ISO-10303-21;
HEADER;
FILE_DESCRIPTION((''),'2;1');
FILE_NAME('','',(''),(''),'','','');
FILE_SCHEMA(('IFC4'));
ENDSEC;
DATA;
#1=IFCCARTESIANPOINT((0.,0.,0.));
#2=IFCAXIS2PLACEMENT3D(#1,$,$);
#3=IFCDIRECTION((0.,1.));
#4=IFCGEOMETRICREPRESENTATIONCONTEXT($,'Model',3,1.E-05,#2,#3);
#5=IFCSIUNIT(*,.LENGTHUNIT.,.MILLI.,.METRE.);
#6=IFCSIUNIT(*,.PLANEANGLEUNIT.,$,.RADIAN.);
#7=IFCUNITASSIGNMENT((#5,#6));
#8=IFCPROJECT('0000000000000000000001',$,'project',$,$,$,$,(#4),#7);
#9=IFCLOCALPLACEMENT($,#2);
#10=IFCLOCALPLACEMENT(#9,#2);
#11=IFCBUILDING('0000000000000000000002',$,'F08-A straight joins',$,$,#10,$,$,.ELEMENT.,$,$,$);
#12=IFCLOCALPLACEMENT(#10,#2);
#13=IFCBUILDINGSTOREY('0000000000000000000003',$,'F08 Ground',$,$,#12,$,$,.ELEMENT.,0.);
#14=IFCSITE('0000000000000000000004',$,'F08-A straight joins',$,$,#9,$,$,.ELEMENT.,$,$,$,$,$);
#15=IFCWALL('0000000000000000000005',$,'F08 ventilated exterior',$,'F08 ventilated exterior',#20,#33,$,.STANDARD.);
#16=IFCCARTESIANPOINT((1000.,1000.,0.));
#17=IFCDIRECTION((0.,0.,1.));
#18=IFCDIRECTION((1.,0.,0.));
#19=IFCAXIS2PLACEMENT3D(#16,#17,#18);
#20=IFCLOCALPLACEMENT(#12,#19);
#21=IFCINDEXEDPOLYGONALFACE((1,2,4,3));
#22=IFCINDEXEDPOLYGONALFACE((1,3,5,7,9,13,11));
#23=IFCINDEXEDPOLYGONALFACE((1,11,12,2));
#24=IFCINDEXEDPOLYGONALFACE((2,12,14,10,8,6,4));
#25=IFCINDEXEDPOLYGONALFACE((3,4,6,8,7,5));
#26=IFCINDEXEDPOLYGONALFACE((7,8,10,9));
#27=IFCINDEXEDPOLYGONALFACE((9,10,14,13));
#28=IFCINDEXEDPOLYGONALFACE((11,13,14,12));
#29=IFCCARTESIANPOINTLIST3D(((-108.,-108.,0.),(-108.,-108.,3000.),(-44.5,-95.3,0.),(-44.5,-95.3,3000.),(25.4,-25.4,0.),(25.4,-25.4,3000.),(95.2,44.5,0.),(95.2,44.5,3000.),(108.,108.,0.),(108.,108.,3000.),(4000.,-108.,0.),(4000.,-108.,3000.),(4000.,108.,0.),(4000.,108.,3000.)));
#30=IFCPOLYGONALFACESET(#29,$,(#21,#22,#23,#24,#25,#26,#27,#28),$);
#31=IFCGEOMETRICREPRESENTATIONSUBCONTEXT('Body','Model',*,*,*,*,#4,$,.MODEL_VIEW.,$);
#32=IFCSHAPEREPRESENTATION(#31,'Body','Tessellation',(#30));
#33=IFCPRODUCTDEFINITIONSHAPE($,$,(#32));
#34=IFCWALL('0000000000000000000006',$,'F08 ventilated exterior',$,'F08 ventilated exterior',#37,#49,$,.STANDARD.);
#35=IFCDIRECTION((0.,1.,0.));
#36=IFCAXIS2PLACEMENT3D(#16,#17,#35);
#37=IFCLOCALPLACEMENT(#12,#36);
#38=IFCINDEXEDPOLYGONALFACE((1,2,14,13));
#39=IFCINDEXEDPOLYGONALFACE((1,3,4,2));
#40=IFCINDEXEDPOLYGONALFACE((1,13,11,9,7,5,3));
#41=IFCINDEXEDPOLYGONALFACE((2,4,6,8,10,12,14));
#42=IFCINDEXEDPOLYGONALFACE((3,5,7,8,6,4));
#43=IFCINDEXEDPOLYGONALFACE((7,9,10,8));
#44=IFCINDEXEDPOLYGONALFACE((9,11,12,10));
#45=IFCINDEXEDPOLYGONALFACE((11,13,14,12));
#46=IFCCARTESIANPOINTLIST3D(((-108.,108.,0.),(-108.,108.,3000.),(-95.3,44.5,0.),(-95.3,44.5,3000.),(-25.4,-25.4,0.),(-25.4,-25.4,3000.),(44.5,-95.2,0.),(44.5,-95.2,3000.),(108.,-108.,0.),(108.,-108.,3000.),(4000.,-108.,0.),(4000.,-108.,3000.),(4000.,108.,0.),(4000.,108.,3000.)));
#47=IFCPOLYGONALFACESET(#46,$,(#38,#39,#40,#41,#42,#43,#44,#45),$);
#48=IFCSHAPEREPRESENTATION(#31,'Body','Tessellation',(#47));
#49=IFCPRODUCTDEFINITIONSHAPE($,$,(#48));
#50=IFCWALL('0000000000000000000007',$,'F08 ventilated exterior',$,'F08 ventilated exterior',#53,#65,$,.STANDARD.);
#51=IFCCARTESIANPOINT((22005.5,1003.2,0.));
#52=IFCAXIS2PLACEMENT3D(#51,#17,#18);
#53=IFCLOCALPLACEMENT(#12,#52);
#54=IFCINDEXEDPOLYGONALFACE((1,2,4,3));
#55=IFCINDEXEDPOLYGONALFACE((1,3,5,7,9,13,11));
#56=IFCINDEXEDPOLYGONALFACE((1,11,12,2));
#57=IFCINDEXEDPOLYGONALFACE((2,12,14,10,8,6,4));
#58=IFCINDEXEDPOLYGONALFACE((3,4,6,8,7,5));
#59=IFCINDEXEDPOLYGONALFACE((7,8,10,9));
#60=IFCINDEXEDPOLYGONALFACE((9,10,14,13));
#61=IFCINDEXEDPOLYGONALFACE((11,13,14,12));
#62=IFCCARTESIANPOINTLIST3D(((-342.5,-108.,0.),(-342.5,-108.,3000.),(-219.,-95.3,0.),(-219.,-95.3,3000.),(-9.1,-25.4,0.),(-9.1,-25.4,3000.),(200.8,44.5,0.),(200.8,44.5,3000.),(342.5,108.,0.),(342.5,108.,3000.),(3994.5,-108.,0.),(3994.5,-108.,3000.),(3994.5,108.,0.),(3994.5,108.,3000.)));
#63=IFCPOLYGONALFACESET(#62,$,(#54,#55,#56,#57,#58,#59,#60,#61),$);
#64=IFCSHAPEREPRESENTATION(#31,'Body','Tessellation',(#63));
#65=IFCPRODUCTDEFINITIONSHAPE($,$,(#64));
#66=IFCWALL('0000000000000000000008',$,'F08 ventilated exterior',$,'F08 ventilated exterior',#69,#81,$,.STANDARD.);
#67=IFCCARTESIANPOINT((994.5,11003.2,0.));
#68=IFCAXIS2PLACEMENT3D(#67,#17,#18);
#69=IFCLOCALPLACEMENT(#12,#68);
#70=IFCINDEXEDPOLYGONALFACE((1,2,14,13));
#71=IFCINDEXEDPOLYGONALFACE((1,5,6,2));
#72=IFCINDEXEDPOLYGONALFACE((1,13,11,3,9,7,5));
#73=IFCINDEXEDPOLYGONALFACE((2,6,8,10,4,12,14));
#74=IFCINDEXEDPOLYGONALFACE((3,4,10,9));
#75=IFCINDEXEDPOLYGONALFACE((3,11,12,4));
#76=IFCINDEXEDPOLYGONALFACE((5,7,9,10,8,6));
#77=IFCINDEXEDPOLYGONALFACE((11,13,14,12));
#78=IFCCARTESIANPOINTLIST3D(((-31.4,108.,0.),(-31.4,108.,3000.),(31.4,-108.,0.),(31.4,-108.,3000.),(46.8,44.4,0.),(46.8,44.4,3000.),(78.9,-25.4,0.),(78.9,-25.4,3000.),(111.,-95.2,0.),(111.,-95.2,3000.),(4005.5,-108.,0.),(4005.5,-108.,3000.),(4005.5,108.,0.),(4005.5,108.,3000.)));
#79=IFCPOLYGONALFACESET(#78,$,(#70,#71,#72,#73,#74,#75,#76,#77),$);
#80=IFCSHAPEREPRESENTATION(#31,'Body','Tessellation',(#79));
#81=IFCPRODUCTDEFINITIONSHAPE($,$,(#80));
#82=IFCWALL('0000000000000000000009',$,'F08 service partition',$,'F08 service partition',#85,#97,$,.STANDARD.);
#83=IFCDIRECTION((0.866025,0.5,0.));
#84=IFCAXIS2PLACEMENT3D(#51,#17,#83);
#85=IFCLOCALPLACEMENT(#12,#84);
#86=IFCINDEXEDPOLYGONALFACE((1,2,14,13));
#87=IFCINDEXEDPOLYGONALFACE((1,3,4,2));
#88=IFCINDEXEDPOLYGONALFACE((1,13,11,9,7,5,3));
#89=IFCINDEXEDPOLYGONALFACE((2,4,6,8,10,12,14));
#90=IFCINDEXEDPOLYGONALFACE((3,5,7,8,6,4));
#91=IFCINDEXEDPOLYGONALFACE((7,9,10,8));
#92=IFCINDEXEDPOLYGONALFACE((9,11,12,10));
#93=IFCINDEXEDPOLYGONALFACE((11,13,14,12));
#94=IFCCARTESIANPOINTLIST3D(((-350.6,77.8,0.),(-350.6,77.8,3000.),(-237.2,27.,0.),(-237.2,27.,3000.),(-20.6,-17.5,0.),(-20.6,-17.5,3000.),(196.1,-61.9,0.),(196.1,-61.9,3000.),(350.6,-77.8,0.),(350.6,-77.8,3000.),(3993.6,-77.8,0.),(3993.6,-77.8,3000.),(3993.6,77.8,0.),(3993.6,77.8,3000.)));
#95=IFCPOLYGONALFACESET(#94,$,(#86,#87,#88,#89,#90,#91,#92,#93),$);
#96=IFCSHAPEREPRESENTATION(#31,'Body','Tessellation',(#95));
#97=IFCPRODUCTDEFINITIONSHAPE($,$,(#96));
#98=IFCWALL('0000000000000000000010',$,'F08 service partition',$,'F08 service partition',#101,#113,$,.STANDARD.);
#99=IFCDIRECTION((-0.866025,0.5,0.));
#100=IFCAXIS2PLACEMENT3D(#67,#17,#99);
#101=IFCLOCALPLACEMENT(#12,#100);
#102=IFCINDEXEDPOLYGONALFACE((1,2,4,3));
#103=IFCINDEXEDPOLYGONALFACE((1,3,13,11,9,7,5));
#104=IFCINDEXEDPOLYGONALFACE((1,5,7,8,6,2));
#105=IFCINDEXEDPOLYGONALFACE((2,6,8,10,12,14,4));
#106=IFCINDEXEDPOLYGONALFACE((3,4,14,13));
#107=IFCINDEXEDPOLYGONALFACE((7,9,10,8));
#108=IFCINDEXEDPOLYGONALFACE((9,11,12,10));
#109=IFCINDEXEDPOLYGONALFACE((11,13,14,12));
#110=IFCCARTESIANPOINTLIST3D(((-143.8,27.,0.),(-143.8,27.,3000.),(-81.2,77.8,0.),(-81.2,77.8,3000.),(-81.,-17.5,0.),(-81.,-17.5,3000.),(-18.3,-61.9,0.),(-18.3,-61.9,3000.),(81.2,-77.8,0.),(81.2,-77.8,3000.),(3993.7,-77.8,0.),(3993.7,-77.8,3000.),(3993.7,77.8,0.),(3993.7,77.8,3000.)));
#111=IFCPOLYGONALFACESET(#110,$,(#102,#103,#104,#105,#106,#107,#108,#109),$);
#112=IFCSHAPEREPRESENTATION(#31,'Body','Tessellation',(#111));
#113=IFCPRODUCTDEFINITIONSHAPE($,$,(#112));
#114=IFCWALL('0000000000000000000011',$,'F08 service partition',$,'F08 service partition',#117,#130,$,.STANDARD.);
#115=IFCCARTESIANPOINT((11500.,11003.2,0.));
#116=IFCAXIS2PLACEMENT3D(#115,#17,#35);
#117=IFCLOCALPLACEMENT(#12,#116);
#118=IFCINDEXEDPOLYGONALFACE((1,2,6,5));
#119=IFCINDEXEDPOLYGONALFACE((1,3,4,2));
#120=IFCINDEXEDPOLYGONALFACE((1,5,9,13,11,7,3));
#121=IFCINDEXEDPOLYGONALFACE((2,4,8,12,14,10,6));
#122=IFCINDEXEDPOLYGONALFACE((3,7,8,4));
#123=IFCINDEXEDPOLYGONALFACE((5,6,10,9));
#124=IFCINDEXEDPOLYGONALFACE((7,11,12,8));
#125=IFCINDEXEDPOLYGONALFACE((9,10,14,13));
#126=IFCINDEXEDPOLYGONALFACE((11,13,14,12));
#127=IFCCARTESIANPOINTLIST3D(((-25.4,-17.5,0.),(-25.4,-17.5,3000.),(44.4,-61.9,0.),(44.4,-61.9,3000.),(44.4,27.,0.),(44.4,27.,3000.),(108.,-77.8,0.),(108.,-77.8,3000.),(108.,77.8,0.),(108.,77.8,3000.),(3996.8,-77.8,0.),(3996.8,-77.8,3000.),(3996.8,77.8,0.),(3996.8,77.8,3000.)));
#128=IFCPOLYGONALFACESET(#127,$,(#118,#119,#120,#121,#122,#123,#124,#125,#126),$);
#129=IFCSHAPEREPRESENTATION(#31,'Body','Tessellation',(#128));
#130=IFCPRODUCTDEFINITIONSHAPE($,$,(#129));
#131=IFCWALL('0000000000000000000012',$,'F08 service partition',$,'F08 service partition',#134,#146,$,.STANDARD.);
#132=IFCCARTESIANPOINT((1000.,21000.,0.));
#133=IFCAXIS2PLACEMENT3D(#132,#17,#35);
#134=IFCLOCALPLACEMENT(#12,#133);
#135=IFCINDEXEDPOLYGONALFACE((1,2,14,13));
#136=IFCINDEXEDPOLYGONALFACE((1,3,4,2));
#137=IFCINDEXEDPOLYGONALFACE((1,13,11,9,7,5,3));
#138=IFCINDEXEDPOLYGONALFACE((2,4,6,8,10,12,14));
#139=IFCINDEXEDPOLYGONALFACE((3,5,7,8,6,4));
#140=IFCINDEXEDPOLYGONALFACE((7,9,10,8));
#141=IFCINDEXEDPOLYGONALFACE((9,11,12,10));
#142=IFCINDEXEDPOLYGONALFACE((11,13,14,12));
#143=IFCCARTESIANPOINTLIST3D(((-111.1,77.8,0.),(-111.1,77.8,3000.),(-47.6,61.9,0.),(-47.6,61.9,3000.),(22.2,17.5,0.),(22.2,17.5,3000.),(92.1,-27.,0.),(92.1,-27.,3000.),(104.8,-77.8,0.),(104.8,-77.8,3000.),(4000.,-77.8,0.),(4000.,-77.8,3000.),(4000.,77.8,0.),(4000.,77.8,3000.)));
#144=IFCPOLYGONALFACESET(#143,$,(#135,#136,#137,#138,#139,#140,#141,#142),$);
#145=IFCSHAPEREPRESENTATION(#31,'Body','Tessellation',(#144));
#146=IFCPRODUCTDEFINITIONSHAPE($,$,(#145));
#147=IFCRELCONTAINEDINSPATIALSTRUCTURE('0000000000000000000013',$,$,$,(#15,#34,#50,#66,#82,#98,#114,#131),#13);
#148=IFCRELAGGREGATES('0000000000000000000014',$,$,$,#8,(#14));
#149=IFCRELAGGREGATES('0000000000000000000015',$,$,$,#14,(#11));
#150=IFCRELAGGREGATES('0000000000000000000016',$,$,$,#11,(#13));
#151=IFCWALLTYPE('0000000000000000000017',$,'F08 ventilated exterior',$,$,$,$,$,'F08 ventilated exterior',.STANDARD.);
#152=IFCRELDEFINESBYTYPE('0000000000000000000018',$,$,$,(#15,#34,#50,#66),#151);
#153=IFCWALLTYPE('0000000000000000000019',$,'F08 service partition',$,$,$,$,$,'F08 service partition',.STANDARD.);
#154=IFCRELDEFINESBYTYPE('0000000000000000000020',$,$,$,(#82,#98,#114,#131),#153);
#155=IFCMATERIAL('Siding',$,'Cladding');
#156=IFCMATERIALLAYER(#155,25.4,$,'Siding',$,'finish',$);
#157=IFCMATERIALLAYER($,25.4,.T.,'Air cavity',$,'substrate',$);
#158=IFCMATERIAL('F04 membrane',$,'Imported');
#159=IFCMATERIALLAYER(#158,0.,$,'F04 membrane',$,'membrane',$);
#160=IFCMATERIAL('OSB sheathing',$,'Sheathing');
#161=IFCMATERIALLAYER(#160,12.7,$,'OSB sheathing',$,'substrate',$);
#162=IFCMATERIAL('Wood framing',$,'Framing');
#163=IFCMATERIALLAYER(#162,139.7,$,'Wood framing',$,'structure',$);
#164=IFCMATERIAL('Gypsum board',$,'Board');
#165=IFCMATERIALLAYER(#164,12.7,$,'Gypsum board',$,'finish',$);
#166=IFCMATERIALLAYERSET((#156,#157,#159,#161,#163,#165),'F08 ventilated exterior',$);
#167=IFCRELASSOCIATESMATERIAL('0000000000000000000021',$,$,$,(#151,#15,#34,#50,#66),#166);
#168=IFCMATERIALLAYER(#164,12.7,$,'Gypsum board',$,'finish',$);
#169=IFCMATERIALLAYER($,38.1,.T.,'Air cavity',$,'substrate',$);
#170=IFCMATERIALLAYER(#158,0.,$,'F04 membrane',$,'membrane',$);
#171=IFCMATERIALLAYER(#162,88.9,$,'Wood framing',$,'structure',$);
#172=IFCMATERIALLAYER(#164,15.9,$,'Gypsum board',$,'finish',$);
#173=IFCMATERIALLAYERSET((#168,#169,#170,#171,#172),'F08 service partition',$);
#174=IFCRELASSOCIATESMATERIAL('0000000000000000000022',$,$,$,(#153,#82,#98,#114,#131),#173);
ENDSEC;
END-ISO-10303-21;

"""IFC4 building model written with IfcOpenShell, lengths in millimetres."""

from ifc_helpers import new_model, si_unit, direction, frame, origin, place, context, subcontext, project, spatial, polyline, outline, extrude, material, layer, layer_set, layer_usage, type_object, element, save


model = new_model("IFC4")

# Units and contexts
model_context = context("Model", 3, precision=1e-05, world=origin(), true_north=direction((0.0, 1.0)))
body_context = subcontext(model_context, "Body", "Model", "MODEL_VIEW")
ifc_project = project(units=[si_unit("LENGTHUNIT", "METRE", prefix="MILLI"), si_unit("PLANEANGLEUNIT", "RADIAN")], contexts=[model_context])

# Site, building, storey
site_placement = place(None, origin())
site = spatial("IfcSite", under=ifc_project, at=site_placement, Name="F08-A straight joins", CompositionType="ELEMENT")
building_placement = place(site_placement, origin())
building = spatial("IfcBuilding", under=site, at=building_placement, Name="F08-A straight joins", CompositionType="ELEMENT")
storey_placement = place(building_placement, origin())
storey = spatial("IfcBuildingStorey", under=building, at=storey_placement, Name="F08 Ground", CompositionType="ELEMENT", Elevation=0.0)

# Walls
ifc_material_1 = material(Name="Siding", Category="Cladding")
ifc_layer_1 = layer(ifc_material_1, 25.4, Name="Siding", Category="finish")
ifc_layer_2 = layer(None, 25.4, ventilated=True, Name="Air cavity", Category="substrate")
ifc_material_2 = material(Name="F04 membrane", Category="Imported")
ifc_layer_3 = layer(ifc_material_2, 0.0, Name="F04 membrane", Category="membrane")
ifc_material_3 = material(Name="OSB sheathing", Category="Sheathing")
ifc_layer_4 = layer(ifc_material_3, 12.7, Name="OSB sheathing", Category="substrate")
ifc_material_4 = material(Name="Wood framing", Category="Framing")
ifc_layer_5 = layer(ifc_material_4, 139.7, Name="Wood framing", Category="structure")
ifc_material_5 = material(Name="Gypsum board", Category="Board")
ifc_layer_6 = layer(ifc_material_5, 12.7, Name="Gypsum board", Category="finish")
ifc_layer_set_1 = layer_set([ifc_layer_1, ifc_layer_2, ifc_layer_3, ifc_layer_4, ifc_layer_5, ifc_layer_6], Name="F08 ventilated exterior")
ifc_layer_usage_1 = layer_usage(ifc_layer_set_1, "AXIS2", "NEGATIVE", 108.0)
wall_type_1 = type_object("IfcWallType", Name="F08 ventilated exterior", ElementType="F08 ventilated exterior", PredefinedType="STANDARD", material=ifc_layer_set_1)
wall_1_placement = place(storey_placement, frame((1000.0, 1000.0, 0.0), z_axis=(0.0, 0.0, 1.0), x_axis=(1.0, 0.0, 0.0)))
element("IfcWall", 1, at=wall_1_placement, inside=storey, type_object=wall_type_1, material=ifc_layer_usage_1, Name="F08 ventilated exterior", ObjectType="F08 ventilated exterior", PredefinedType="STANDARD", context=body_context, shape_type="SweptSolid", body=[
    extrude(outline(polyline([(-108.0, -108.0), (4000.0, -108.0), (4000.0, 108.0), (108.0, 108.0), (95.2, 44.5), (25.4, -25.4), (-44.5, -95.2), (-108.0, -108.0)])), origin(), (0.0, 0.0, 1.0), 3000.0),
])
ifc_layer_usage_2 = layer_usage(ifc_layer_set_1, "AXIS2", "NEGATIVE", 108.0)
wall_2_placement = place(storey_placement, frame((1000.0, 1000.0, 0.0), z_axis=(0.0, 0.0, 1.0), x_axis=(0.0, 1.0, 0.0)))
element("IfcWall", 2, at=wall_2_placement, inside=storey, type_object=wall_type_1, material=ifc_layer_usage_2, Name="F08 ventilated exterior", ObjectType="F08 ventilated exterior", PredefinedType="STANDARD", context=body_context, shape_type="SweptSolid", body=[
    extrude(outline(polyline([(108.0, -108.0), (4000.0, -108.0), (4000.0, 108.0), (-108.0, 108.0), (-95.2, 44.5), (-25.4, -25.4), (44.5, -95.2), (108.0, -108.0)])), origin(), (0.0, 0.0, 1.0), 3000.0),
])
ifc_layer_usage_3 = layer_usage(ifc_layer_set_1, "AXIS2", "NEGATIVE", 108.0)
wall_3_placement = place(storey_placement, frame((22005.5, 1003.2, 0.0), z_axis=(0.0, 0.0, 1.0), x_axis=(1.0, 0.0, 0.0)))
element("IfcWall", 3, at=wall_3_placement, inside=storey, type_object=wall_type_1, material=ifc_layer_usage_3, Name="F08 ventilated exterior", ObjectType="F08 ventilated exterior", PredefinedType="STANDARD", context=body_context, shape_type="SweptSolid", body=[
    extrude(outline(polyline([(-342.5, -108.0), (3994.5, -108.0), (3994.5, 108.0), (342.5, 108.0), (200.8, 44.5), (-9.1, -25.4), (-219.0, -95.2), (-342.5, -108.0)])), origin(), (0.0, 0.0, 1.0), 3000.0),
])
ifc_layer_usage_4 = layer_usage(ifc_layer_set_1, "AXIS2", "NEGATIVE", 108.0)
wall_4_placement = place(storey_placement, frame((994.5, 11003.2, 0.0), z_axis=(0.0, 0.0, 1.0), x_axis=(1.0, 0.0, 0.0)))
element("IfcWall", 4, at=wall_4_placement, inside=storey, type_object=wall_type_1, material=ifc_layer_usage_4, Name="F08 ventilated exterior", ObjectType="F08 ventilated exterior", PredefinedType="STANDARD", context=body_context, shape_type="SweptSolid", body=[
    extrude(outline(polyline([(31.4, -108.0), (4005.5, -108.0), (4005.5, 108.0), (-31.4, 108.0), (46.8, 44.5), (78.9, -25.4), (111.0, -95.2), (31.4, -108.0)])), origin(), (0.0, 0.0, 1.0), 3000.0),
])

# Walls
ifc_layer_7 = layer(ifc_material_5, 12.7, Name="Gypsum board", Category="finish")
ifc_layer_8 = layer(None, 38.1, ventilated=True, Name="Air cavity", Category="substrate")
ifc_layer_9 = layer(ifc_material_2, 0.0, Name="F04 membrane", Category="membrane")
ifc_layer_10 = layer(ifc_material_4, 88.9, Name="Wood framing", Category="structure")
ifc_layer_11 = layer(ifc_material_5, 15.9, Name="Gypsum board", Category="finish")
ifc_layer_set_2 = layer_set([ifc_layer_7, ifc_layer_8, ifc_layer_9, ifc_layer_10, ifc_layer_11], Name="F08 service partition")
wall_type_2 = type_object("IfcWallType", Name="F08 service partition", ElementType="F08 service partition", PredefinedType="STANDARD", material=ifc_layer_set_2)
ifc_layer_usage_5 = layer_usage(ifc_layer_set_2, "AXIS2", "NEGATIVE", 77.8)
wall_5_placement = place(storey_placement, frame((22005.5, 1003.2, 0.0), z_axis=(0.0, 0.0, 1.0), x_axis=(0.866025, 0.5, 0.0)))
element("IfcWall", 5, at=wall_5_placement, inside=storey, type_object=wall_type_2, material=ifc_layer_usage_5, Name="F08 service partition", ObjectType="F08 service partition", PredefinedType="STANDARD", context=body_context, shape_type="SweptSolid", body=[
    extrude(outline(polyline([(350.6, -77.8), (3993.7, -77.8), (3993.7, 77.8), (-350.6, 77.8), (-237.2, 27.0), (-20.6, -17.5), (196.1, -61.9), (350.6, -77.8)])), origin(), (0.0, 0.0, 1.0), 3000.0),
])
ifc_layer_usage_6 = layer_usage(ifc_layer_set_2, "AXIS2", "NEGATIVE", 77.8)
wall_6_placement = place(storey_placement, frame((994.5, 11003.2, 0.0), z_axis=(0.0, 0.0, 1.0), x_axis=(-0.866025, 0.5, 0.0)))
element("IfcWall", 6, at=wall_6_placement, inside=storey, type_object=wall_type_2, material=ifc_layer_usage_6, Name="F08 service partition", ObjectType="F08 service partition", PredefinedType="STANDARD", context=body_context, shape_type="SweptSolid", body=[
    extrude(outline(polyline([(81.2, -77.8), (3993.7, -77.8), (3993.7, 77.8), (-81.2, 77.8), (-143.8, 27.0), (-81.0, -17.5), (-18.3, -61.9), (81.2, -77.8)])), origin(), (0.0, 0.0, 1.0), 3000.0),
])
ifc_layer_usage_7 = layer_usage(ifc_layer_set_2, "AXIS2", "NEGATIVE", 77.8)
wall_7_placement = place(storey_placement, frame((11500.0, 11003.2, 0.0), z_axis=(0.0, 0.0, 1.0), x_axis=(0.0, 1.0, 0.0)))
element("IfcWall", 7, at=wall_7_placement, inside=storey, type_object=wall_type_2, material=ifc_layer_usage_7, Name="F08 service partition", ObjectType="F08 service partition", PredefinedType="STANDARD", context=body_context, shape_type="SweptSolid", body=[
    extrude(outline(polyline([(108.0, -77.8), (3996.8, -77.8), (3996.8, 77.8), (108.0, 77.8), (44.5, 27.0), (-25.4, -17.5), (44.5, -61.9), (108.0, -77.8)])), origin(), (0.0, 0.0, 1.0), 3000.0),
])
ifc_layer_usage_8 = layer_usage(ifc_layer_set_2, "AXIS2", "POSITIVE", -77.8)
wall_8_placement = place(storey_placement, frame((1000.0, 21000.0, 0.0), z_axis=(0.0, 0.0, 1.0), x_axis=(0.0, 1.0, 0.0)))
element("IfcWall", 8, at=wall_8_placement, inside=storey, type_object=wall_type_2, material=ifc_layer_usage_8, Name="F08 service partition", ObjectType="F08 service partition", PredefinedType="STANDARD", context=body_context, shape_type="SweptSolid", body=[
    extrude(outline(polyline([(104.8, -77.8), (4000.0, -77.8), (4000.0, 77.8), (-111.1, 77.8), (-47.6, 61.9), (22.2, 17.5), (92.1, -27.0), (104.8, -77.8)])), origin(), (0.0, 0.0, 1.0), 3000.0),
])

save(model, "model.ifc")
